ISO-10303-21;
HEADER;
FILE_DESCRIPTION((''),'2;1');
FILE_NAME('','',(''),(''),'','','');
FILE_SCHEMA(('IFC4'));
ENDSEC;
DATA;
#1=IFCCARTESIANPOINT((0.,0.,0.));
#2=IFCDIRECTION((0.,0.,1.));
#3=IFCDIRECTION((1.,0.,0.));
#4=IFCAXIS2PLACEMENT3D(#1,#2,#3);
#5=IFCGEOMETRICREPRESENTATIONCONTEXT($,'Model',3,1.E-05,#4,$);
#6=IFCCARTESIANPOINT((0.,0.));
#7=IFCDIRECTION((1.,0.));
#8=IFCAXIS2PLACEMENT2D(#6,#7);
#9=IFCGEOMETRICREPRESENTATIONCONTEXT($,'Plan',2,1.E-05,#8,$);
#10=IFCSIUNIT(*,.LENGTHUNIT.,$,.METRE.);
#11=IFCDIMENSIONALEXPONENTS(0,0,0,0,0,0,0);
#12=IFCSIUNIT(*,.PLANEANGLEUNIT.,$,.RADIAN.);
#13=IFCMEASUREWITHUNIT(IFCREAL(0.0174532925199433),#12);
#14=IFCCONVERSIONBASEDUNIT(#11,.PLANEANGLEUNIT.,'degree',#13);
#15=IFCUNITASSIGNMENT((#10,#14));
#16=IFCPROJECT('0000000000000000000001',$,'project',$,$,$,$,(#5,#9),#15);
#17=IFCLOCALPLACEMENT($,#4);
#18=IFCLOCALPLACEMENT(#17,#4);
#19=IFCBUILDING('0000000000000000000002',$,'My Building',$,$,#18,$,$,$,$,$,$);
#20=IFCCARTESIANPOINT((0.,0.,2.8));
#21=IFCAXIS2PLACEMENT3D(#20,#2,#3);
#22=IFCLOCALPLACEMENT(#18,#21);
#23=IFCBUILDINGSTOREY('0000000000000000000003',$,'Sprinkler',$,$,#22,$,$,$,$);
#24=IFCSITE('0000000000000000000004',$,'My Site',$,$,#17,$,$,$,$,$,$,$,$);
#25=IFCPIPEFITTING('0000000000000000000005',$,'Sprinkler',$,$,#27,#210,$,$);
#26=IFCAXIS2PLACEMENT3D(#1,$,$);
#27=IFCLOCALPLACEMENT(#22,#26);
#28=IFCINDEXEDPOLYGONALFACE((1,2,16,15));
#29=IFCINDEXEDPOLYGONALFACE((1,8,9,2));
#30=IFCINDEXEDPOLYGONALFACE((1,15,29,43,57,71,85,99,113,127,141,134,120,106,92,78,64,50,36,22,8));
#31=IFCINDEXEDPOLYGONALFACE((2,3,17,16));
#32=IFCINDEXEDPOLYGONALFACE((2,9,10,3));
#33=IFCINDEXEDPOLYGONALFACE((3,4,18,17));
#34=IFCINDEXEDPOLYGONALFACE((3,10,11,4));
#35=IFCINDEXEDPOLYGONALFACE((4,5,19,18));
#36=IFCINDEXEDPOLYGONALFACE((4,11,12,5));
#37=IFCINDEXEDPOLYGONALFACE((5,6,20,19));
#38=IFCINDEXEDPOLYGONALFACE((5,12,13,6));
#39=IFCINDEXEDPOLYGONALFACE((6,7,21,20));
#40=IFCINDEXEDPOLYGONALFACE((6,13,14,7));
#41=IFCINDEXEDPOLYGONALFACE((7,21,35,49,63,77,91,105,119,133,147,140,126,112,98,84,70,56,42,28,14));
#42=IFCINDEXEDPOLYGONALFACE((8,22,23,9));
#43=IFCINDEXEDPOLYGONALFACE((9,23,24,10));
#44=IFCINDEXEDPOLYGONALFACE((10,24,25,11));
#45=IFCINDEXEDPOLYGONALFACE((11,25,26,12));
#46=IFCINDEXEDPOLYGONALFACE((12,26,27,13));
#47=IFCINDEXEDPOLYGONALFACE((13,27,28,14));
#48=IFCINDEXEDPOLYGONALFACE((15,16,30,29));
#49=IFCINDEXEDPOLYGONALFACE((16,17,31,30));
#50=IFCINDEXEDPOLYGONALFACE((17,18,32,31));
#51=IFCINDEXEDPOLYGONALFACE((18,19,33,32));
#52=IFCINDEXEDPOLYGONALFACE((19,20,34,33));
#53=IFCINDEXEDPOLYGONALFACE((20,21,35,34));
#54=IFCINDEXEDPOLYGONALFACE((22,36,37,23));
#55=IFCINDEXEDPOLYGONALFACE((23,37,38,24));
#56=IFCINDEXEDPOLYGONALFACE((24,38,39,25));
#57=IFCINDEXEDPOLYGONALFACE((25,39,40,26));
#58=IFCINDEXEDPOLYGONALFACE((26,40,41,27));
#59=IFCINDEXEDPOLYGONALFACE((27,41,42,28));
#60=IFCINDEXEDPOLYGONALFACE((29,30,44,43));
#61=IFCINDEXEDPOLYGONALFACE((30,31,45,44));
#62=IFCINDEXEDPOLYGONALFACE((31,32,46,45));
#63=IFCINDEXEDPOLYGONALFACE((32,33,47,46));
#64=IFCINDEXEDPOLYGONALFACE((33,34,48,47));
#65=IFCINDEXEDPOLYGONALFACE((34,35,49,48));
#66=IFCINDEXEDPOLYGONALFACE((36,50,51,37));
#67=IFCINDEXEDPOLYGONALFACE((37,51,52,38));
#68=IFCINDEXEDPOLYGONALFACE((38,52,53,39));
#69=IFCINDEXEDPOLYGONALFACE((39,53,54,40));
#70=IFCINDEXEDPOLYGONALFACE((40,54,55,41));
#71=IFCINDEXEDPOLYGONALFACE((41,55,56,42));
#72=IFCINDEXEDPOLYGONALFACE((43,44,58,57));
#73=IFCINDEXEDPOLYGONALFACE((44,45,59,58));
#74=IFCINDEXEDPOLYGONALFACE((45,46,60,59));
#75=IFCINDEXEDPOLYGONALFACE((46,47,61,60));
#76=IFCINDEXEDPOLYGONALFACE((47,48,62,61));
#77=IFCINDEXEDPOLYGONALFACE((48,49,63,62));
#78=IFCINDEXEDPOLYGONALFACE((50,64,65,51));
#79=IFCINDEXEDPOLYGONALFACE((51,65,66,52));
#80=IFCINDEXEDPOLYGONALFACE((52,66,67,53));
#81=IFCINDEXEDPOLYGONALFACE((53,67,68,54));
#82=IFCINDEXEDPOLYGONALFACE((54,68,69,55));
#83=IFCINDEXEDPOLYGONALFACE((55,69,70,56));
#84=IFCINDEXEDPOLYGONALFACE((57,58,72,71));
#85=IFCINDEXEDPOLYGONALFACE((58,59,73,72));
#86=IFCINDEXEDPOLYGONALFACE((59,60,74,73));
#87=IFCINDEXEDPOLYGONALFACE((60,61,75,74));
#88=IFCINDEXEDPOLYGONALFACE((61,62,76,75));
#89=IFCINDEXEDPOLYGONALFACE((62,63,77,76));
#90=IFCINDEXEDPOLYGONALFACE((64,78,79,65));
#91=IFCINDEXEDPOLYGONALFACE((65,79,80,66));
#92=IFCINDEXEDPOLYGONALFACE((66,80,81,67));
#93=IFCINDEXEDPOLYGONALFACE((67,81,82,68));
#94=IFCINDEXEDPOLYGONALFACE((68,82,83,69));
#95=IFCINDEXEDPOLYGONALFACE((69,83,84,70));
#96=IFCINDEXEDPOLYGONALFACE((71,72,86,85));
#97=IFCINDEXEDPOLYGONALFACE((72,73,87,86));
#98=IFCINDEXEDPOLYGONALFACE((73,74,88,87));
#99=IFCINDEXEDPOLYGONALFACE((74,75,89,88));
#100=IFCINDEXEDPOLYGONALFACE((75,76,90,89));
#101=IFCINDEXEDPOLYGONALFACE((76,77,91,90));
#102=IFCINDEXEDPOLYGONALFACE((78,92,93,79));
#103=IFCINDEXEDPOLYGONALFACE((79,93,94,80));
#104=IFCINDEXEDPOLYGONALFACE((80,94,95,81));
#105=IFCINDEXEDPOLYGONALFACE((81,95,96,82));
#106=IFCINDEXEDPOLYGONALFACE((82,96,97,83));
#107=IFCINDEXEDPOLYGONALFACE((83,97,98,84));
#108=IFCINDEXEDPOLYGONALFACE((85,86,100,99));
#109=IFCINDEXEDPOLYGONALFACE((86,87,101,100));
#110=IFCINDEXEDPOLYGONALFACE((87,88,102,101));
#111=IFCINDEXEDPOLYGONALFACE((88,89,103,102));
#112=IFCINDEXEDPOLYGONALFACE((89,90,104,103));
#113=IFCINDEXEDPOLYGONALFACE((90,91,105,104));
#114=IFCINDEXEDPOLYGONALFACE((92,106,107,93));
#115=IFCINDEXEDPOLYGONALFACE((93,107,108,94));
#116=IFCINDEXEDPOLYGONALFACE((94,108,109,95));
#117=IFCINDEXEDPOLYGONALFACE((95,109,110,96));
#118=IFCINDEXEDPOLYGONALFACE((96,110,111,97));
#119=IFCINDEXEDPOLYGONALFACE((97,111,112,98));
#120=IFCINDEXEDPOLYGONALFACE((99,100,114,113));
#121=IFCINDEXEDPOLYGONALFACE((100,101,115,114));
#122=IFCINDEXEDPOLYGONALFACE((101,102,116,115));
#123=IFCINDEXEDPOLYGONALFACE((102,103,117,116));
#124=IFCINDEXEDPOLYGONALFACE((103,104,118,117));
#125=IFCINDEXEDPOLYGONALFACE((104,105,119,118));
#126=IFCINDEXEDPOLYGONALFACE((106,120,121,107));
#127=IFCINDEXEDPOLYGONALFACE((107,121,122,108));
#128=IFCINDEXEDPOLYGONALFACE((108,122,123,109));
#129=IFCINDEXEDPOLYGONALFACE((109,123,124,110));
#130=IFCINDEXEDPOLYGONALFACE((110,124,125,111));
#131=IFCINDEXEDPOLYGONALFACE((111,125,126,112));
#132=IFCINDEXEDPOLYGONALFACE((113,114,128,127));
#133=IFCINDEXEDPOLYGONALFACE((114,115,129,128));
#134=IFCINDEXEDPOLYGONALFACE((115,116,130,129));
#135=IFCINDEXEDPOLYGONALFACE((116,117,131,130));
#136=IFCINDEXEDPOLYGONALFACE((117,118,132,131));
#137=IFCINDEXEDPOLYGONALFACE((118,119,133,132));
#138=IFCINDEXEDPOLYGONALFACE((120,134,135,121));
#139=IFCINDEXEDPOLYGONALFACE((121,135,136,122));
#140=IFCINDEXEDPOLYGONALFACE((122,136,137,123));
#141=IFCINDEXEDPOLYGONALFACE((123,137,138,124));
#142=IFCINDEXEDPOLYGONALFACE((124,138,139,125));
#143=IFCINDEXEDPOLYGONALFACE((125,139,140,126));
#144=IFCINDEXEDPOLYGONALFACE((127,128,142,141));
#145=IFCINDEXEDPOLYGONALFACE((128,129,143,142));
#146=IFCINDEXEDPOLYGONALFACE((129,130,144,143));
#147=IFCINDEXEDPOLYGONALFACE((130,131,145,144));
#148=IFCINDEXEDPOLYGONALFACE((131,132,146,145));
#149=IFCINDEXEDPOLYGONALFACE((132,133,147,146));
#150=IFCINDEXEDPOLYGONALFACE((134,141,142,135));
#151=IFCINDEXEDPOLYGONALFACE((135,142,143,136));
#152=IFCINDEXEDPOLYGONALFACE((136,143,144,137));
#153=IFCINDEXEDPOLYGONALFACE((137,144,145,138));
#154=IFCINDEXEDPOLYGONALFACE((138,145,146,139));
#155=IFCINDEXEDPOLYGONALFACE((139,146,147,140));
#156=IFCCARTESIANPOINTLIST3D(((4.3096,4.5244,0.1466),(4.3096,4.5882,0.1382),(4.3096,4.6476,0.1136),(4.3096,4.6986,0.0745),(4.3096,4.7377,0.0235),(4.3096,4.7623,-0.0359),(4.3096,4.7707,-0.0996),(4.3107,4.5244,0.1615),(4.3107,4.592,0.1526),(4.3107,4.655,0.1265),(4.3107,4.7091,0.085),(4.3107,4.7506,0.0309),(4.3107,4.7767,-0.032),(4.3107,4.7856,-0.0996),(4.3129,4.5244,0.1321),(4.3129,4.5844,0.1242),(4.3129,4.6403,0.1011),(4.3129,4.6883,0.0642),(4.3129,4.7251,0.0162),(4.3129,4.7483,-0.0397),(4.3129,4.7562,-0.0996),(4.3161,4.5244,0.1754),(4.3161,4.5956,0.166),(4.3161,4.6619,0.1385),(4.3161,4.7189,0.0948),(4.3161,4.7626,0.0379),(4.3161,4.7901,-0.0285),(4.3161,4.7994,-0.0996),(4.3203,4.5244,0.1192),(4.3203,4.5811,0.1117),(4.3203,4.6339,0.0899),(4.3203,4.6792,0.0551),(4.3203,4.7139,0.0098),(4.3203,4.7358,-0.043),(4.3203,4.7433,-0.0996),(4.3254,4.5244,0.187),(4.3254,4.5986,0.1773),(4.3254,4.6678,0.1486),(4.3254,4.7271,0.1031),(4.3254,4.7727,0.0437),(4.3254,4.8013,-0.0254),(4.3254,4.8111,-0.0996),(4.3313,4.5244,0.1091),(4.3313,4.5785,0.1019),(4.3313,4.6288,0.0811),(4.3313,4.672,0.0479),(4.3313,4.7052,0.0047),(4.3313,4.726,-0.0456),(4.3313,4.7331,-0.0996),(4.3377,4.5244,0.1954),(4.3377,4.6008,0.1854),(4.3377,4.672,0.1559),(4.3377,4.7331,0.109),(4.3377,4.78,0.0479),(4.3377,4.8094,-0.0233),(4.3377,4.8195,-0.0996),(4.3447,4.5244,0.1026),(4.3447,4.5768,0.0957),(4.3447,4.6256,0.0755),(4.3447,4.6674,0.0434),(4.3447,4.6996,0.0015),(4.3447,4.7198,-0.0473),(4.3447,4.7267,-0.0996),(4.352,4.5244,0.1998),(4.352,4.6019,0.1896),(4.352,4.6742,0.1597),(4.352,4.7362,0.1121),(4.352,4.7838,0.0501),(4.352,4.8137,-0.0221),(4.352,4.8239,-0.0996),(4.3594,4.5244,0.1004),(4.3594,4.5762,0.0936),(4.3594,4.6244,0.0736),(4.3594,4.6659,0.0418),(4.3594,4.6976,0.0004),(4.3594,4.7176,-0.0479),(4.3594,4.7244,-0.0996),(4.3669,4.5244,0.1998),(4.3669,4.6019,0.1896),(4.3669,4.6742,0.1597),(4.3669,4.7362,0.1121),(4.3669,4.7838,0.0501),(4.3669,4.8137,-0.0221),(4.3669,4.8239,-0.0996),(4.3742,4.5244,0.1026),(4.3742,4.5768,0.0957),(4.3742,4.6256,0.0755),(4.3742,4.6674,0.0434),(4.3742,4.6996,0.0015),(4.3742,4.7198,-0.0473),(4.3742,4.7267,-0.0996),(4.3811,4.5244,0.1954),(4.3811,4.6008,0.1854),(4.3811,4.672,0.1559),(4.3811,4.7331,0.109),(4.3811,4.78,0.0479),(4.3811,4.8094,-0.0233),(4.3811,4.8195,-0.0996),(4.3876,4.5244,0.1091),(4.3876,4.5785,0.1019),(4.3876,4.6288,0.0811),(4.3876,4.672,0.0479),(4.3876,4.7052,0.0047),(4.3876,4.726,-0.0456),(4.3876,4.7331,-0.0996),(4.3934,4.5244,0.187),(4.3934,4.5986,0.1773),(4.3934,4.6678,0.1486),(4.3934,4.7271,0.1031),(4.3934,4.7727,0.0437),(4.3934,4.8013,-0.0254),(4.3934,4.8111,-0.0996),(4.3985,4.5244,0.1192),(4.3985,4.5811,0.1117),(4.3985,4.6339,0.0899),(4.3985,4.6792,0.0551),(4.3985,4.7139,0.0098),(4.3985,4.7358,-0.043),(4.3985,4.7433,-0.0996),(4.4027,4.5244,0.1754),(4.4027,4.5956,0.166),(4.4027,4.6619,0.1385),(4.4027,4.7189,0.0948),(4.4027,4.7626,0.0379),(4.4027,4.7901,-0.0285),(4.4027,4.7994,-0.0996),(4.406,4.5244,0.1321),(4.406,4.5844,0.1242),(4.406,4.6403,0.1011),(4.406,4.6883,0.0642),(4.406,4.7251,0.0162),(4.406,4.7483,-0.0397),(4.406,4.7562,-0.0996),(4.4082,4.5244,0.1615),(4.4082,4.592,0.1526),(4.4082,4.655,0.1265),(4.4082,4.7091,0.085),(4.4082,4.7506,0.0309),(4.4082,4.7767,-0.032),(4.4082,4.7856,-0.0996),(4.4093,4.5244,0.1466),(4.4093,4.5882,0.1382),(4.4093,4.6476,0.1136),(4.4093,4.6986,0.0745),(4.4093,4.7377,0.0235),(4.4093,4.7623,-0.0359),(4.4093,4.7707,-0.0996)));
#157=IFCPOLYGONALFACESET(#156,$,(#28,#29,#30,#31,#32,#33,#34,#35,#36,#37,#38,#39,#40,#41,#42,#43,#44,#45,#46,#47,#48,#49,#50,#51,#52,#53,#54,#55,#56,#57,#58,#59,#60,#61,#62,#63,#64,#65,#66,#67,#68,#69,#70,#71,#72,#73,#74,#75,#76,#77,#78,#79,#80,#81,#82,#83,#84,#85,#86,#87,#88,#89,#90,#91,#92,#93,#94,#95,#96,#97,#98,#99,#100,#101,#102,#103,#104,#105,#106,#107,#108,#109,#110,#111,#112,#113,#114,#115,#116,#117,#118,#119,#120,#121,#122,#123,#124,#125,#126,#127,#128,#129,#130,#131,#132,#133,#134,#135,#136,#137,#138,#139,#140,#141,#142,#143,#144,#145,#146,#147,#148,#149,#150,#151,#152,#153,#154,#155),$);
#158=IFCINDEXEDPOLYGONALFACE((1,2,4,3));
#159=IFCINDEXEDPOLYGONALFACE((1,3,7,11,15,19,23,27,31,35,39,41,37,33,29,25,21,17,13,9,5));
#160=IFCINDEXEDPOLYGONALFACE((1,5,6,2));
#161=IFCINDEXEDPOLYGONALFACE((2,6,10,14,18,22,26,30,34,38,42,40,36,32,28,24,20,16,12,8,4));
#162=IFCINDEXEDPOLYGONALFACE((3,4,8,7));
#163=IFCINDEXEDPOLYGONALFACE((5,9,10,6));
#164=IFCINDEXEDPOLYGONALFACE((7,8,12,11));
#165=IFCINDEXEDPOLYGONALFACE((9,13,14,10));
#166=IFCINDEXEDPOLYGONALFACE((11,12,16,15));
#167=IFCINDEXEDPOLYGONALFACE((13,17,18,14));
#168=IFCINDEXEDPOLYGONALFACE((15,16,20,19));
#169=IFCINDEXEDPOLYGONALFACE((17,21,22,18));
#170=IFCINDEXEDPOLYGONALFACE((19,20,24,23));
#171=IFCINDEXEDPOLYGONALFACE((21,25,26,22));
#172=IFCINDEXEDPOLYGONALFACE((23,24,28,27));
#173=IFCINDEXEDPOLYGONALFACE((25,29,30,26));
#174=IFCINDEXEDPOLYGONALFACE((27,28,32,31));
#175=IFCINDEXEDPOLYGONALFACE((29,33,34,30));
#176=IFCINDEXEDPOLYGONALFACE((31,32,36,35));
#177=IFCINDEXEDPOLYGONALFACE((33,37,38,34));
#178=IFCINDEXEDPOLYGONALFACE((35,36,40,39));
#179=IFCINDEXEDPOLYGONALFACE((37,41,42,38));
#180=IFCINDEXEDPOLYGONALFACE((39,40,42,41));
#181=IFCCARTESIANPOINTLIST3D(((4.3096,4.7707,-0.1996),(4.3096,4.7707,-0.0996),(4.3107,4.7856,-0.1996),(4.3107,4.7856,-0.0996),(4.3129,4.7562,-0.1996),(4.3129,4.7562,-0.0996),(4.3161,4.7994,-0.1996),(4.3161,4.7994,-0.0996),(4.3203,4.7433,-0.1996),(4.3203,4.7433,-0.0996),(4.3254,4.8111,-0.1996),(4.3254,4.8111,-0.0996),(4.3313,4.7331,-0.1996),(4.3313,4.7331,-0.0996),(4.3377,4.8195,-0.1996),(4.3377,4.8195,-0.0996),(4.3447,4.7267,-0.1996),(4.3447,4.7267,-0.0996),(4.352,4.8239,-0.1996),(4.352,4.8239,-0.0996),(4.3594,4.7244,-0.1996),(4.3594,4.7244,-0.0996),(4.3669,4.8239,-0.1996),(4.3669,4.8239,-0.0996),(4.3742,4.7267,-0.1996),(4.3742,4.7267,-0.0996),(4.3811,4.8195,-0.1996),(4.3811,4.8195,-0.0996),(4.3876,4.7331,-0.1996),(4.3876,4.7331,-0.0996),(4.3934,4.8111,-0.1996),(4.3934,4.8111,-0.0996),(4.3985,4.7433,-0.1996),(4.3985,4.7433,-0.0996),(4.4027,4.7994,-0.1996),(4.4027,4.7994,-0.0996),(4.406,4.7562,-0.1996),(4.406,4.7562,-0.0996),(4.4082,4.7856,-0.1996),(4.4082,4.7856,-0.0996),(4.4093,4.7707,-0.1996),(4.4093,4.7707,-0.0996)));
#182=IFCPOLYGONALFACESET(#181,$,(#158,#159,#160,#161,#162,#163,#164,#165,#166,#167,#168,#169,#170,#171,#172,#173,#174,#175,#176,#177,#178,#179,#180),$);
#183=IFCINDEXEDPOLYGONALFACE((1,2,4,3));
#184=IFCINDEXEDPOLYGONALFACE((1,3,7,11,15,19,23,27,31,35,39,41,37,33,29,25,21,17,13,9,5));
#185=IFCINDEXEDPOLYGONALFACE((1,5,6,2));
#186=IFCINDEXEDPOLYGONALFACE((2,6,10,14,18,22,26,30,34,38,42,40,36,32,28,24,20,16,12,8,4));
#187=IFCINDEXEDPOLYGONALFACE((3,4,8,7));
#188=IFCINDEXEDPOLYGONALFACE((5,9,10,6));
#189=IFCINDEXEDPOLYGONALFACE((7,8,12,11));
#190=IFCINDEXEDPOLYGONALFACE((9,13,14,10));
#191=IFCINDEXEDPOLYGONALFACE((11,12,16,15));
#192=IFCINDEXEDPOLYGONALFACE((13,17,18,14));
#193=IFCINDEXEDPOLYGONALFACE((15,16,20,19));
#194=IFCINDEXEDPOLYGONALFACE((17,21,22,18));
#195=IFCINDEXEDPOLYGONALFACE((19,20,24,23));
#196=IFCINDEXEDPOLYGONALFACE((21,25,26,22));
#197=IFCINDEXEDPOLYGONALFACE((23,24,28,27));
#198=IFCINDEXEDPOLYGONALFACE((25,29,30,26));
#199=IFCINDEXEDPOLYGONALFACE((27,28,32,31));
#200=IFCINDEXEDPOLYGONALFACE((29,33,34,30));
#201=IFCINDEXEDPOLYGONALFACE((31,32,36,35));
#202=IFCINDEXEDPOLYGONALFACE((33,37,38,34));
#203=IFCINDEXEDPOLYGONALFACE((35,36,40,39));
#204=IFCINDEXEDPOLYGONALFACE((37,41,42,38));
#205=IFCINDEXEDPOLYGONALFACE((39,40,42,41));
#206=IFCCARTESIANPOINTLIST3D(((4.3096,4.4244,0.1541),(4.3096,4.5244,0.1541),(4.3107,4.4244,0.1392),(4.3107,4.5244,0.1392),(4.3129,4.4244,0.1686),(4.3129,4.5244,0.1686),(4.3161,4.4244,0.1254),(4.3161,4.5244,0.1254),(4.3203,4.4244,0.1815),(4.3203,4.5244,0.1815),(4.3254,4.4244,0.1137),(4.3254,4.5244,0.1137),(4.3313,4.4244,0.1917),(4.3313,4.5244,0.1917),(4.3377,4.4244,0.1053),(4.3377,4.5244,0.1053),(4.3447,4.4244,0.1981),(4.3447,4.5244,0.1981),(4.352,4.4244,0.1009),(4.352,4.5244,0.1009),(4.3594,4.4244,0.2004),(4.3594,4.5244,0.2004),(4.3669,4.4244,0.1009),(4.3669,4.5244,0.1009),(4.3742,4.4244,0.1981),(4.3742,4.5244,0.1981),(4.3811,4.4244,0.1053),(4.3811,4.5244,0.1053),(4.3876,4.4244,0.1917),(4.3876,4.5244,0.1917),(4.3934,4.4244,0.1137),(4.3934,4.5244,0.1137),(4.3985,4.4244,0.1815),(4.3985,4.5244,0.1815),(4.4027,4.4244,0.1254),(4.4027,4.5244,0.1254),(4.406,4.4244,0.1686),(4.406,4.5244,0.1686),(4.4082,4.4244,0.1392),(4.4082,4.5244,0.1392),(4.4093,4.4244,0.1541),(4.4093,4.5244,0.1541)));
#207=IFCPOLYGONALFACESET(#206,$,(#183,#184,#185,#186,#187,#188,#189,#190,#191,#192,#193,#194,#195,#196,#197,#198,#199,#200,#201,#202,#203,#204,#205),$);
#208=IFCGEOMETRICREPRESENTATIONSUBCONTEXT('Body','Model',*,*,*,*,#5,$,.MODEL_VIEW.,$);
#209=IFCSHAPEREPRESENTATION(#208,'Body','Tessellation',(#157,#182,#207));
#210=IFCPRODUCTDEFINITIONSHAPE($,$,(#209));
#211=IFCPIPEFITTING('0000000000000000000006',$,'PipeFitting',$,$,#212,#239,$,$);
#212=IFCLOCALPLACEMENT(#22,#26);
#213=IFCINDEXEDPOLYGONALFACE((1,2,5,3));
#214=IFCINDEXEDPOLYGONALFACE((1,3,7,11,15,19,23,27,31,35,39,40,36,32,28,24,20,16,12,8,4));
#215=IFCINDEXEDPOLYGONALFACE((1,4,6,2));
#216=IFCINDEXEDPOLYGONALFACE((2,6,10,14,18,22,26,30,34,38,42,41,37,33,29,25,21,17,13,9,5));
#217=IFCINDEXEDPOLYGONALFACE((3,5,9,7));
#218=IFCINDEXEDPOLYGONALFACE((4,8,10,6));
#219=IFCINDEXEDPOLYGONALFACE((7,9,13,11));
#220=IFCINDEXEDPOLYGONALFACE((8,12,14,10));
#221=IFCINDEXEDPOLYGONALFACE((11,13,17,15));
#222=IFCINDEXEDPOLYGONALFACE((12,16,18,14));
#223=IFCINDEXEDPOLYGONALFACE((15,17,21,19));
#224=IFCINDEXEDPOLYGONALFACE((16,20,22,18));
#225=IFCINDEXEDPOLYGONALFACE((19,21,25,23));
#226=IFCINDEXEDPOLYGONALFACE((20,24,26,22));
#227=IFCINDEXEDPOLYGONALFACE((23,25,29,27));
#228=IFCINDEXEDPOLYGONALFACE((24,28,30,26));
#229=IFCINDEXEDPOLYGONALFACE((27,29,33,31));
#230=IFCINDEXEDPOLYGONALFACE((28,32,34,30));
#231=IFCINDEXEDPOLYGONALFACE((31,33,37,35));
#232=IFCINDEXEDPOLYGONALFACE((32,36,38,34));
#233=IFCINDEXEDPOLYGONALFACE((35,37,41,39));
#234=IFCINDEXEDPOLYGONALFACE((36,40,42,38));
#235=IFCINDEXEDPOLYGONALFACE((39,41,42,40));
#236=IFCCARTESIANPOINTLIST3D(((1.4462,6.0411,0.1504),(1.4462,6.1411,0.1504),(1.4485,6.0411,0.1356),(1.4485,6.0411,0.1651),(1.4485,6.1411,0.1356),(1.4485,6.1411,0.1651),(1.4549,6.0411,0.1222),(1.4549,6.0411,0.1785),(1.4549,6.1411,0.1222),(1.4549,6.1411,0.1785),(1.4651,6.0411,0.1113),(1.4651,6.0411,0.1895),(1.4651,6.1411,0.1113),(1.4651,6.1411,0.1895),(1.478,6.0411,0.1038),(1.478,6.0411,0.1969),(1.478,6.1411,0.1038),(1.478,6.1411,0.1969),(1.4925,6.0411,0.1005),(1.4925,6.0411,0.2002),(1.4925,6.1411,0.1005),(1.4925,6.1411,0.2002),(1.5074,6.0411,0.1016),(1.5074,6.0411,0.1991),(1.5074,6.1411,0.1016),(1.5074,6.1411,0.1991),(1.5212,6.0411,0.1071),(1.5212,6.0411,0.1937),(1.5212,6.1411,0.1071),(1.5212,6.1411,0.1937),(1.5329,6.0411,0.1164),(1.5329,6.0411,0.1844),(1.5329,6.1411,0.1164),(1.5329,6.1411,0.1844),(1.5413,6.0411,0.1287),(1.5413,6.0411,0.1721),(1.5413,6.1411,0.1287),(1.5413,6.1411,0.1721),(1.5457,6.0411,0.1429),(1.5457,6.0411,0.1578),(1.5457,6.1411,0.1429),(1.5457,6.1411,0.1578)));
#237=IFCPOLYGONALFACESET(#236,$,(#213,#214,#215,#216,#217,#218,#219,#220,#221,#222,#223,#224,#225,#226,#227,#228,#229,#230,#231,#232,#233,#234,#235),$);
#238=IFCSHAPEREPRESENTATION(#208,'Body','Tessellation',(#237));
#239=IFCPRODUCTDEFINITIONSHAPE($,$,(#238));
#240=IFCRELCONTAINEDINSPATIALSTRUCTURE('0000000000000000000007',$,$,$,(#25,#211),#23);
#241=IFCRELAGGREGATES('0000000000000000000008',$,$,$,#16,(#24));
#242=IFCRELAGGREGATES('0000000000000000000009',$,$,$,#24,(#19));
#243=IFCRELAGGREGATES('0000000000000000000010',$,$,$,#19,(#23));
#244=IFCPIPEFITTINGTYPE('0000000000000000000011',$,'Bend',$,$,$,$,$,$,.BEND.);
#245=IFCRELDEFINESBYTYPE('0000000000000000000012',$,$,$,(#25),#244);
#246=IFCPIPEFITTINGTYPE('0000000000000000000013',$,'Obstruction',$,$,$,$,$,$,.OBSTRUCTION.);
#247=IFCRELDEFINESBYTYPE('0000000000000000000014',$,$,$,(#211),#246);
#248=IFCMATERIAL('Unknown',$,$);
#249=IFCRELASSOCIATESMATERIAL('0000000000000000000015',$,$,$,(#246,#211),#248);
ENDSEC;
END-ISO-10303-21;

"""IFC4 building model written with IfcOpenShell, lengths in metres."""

from ifc_helpers import new_model, entity, si_unit, converted_unit, frame, origin_with_axes, origin_2d_with_axis, place, context, subcontext, project, spatial, circle, extrude, source, transform, mapped, material, material_profile, profile_set, profile_usage, type_object, type_shapes, element, save


model = new_model("IFC4")

# Units and contexts
model_context = context("Model", 3, precision=1e-05, world=origin_with_axes())
plan_context = context("Plan", 2, precision=1e-05, world=origin_2d_with_axis())
body_context = subcontext(model_context, "Body", "Model", "MODEL_VIEW")
ifc_project = project(units=[si_unit("LENGTHUNIT", "METRE"), converted_unit("PLANEANGLEUNIT", "degree", entity("IfcReal", 0.0174532925199433), si_unit("PLANEANGLEUNIT", "RADIAN"), dimensions=[0, 0, 0, 0, 0, 0, 0])], contexts=[model_context, plan_context])

# Site, building, storey
site_placement = place(None, origin_with_axes())
site = spatial("IfcSite", under=ifc_project, at=site_placement, Name="My Site")
building_placement = place(site_placement, origin_with_axes())
building = spatial("IfcBuilding", under=site, at=building_placement, Name="My Building")
storey_placement = place(building_placement, frame((0.0, 0.0, 2.8), z_axis=(0.0, 0.0, 1.0), x_axis=(1.0, 0.0, 0.0)))
storey = spatial("IfcBuildingStorey", under=building, at=storey_placement, Name="Sprinkler")

# Shared definitions
ifc_material = material(Name="Unknown")

# Pipe fittings
pipe_fitting_type_1 = type_object("IfcPipeFittingType", Name="Bend", PredefinedType="BEND")
shared_shape = source(origin_with_axes(), body_context, "Body", "SolidModel", [
    entity("IfcSweptDiskSolid", entity("IfcIndexedPolyCurve", entity("IfcCartesianPointList3D", [[0.0, 0.0, 0.1], [0.0732, 0.0, 0.2768], [0.25, 0.0, 0.35]]), [entity("IfcArcIndex", [1, 2, 3])]), 0.05),
    extrude(circle(Radius=0.05), origin_with_axes(), (0.0, 0.0, 1.0), 0.1),
    extrude(circle(Radius=0.05), frame((0.25, 0.0, 0.35), z_axis=(1.0, 0.0, 0.000001), x_axis=(-0.000001, 0.0, 1.0)), (0.0, 0.0, 1.0), 0.1),
])
type_shapes(pipe_fitting_type_1, [shared_shape])
for number, where, z_axis, x_axis, name in (
    (1, (4.3594, 4.7744, -0.1996), (0.0, -0.000008, 1.0), (0.0, -1.0, -0.000008), "Sprinkler"),
):
    element("IfcPipeFitting", number, at=place(storey_placement, frame(where, z_axis=z_axis, x_axis=x_axis)), inside=storey, type_object=pipe_fitting_type_1, Name=name, context=body_context, shape_type="MappedRepresentation", body=[
        mapped(shared_shape, transform((0.0, 0.0, 0.0), x_axis=(1.0, 0.0, 0.0), y_axis=(0.0, 1.0, 0.0), z_axis=(0.0, 0.0, 1.0), scale=1.0)),
    ])
ifc_material_profile_1 = material_profile(ifc_material, circle(Radius=0.05))
ifc_profile_set_1 = profile_set([ifc_material_profile_1])
ifc_profile_usage_1 = profile_usage(ifc_profile_set_1, cardinal=5)
pipe_fitting_type_2 = type_object("IfcPipeFittingType", Name="Obstruction", PredefinedType="OBSTRUCTION", material=ifc_profile_set_1)
pipe_fitting_1_placement = place(storey_placement, frame((1.4962, 6.0411, 0.1504), z_axis=(0.0, 1.0, -0.000008), x_axis=(-1.0, 0.0, 0.0)))
element("IfcPipeFitting", 2, at=pipe_fitting_1_placement, inside=storey, type_object=pipe_fitting_type_2, material=ifc_profile_usage_1, Name="PipeFitting", context=body_context, shape_type="SweptSolid", body=[
    extrude(circle(Radius=0.05), origin_with_axes(), (0.0, 0.0, 1.0), 0.1),
])

save(model, "model.ifc")
